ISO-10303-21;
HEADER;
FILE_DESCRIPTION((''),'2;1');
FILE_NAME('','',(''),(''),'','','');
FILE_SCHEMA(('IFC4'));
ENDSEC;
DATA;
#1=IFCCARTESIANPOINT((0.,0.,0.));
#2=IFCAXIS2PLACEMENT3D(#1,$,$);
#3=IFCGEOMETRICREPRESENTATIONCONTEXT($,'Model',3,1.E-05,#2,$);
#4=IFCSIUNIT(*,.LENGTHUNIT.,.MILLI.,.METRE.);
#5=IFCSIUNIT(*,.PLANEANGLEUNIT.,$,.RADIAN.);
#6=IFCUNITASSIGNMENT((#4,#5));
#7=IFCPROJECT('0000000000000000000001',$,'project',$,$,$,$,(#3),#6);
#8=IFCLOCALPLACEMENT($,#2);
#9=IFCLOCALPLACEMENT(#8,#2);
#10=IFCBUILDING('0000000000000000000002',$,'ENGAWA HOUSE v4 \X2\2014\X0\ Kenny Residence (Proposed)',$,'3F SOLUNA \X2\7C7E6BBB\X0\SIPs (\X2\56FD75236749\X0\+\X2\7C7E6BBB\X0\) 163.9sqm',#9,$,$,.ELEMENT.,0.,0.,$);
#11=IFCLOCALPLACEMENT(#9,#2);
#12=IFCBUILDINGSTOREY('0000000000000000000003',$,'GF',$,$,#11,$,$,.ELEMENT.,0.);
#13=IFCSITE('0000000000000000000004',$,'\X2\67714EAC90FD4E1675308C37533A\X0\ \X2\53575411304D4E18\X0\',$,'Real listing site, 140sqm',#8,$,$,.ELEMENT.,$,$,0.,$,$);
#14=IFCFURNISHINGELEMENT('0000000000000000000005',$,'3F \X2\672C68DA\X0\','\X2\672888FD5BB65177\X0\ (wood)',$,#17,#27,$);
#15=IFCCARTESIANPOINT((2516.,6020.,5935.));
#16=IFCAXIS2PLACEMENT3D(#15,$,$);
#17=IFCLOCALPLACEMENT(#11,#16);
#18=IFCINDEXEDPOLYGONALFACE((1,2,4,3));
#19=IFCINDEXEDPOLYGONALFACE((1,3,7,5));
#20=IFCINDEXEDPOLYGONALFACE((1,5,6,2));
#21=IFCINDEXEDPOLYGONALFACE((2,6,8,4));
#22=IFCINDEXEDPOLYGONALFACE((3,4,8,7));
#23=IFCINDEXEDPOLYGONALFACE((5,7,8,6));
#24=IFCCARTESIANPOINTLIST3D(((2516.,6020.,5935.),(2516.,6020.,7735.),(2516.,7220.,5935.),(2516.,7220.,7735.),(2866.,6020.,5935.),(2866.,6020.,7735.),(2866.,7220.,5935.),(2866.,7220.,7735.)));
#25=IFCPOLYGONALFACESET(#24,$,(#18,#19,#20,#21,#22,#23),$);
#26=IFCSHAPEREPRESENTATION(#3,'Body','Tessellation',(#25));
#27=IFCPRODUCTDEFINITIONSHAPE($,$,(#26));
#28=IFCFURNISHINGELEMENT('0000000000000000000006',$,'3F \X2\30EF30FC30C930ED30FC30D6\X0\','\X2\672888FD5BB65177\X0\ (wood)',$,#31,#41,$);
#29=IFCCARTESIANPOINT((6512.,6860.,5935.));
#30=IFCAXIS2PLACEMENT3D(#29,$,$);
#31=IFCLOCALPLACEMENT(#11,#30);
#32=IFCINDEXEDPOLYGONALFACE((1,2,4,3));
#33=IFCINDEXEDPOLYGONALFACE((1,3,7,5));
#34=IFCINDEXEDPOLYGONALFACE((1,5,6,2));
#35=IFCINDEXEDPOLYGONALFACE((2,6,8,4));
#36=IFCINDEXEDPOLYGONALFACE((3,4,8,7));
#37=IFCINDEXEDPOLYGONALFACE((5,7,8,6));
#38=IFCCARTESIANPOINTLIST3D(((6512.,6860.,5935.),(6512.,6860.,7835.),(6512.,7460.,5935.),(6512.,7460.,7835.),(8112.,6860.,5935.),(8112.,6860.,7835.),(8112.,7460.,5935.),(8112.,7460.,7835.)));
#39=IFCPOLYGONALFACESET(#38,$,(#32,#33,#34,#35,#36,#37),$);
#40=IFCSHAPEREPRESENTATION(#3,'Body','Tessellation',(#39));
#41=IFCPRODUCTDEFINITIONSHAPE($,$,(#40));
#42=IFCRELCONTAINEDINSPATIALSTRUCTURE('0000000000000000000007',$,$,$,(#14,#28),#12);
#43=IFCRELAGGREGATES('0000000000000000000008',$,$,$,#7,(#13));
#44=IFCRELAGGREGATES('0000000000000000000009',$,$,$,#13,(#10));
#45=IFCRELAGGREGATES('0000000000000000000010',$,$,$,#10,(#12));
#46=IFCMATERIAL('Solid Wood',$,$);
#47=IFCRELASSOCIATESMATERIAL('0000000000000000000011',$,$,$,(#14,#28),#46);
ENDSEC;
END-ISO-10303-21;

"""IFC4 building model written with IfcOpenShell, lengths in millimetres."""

from ifc_helpers import new_model, si_unit, frame, frame_2d, origin, place, context, project, spatial, rectangle, extrude, material, element, save


model = new_model("IFC4")

# Units and contexts
model_context = context("Model", 3, precision=1e-05, world=origin())
ifc_project = project(units=[si_unit("LENGTHUNIT", "METRE", prefix="MILLI"), si_unit("PLANEANGLEUNIT", "RADIAN")], contexts=[model_context])

# Site, building, storey
site_placement = place(None, origin())
site = spatial("IfcSite", under=ifc_project, at=site_placement, Name="東京都世田谷区 南向き丘", ObjectType="Real listing site, 140sqm", CompositionType="ELEMENT", RefElevation=0.0)
building_placement = place(site_placement, origin())
building = spatial("IfcBuilding", under=site, at=building_placement, Name="ENGAWA HOUSE v4 — Kenny Residence (Proposed)", ObjectType="3F SOLUNA 籾殻SIPs (国産杉+籾殻) 163.9sqm", CompositionType="ELEMENT", ElevationOfRefHeight=0.0, ElevationOfTerrain=0.0)
storey_placement = place(building_placement, origin())
storey = spatial("IfcBuildingStorey", under=building, at=storey_placement, Name="GF", CompositionType="ELEMENT", Elevation=0.0)

# Shared definitions
ifc_material_1 = material(Name="Solid Wood")

# Furnishing elements
furnishing_1_placement = place(storey_placement, frame((2516.0, 6020.0, 5935.0)))
element("IfcFurnishingElement", 1, at=furnishing_1_placement, inside=storey, material=ifc_material_1, Name="3F 本棚", Description="木製家具 (wood)", context=model_context, shape_type="SweptSolid", body=[
    extrude(rectangle(XDim=350.0, YDim=1200.0, at=frame_2d((175.0, 600.0))), frame((2516.0, 6020.0, 5935.0)), (0.0, 0.0, 1.0), 1800.0),
])
furnishing_2_placement = place(storey_placement, frame((6512.0, 6860.0, 5935.0)))
element("IfcFurnishingElement", 2, at=furnishing_2_placement, inside=storey, material=ifc_material_1, Name="3F ワードローブ", Description="木製家具 (wood)", context=model_context, shape_type="SweptSolid", body=[
    extrude(rectangle(XDim=1600.0, YDim=600.0, at=frame_2d((800.0, 300.0))), frame((6512.0, 6860.0, 5935.0)), (0.0, 0.0, 1.0), 1900.0),
])

save(model, "model.ifc")
